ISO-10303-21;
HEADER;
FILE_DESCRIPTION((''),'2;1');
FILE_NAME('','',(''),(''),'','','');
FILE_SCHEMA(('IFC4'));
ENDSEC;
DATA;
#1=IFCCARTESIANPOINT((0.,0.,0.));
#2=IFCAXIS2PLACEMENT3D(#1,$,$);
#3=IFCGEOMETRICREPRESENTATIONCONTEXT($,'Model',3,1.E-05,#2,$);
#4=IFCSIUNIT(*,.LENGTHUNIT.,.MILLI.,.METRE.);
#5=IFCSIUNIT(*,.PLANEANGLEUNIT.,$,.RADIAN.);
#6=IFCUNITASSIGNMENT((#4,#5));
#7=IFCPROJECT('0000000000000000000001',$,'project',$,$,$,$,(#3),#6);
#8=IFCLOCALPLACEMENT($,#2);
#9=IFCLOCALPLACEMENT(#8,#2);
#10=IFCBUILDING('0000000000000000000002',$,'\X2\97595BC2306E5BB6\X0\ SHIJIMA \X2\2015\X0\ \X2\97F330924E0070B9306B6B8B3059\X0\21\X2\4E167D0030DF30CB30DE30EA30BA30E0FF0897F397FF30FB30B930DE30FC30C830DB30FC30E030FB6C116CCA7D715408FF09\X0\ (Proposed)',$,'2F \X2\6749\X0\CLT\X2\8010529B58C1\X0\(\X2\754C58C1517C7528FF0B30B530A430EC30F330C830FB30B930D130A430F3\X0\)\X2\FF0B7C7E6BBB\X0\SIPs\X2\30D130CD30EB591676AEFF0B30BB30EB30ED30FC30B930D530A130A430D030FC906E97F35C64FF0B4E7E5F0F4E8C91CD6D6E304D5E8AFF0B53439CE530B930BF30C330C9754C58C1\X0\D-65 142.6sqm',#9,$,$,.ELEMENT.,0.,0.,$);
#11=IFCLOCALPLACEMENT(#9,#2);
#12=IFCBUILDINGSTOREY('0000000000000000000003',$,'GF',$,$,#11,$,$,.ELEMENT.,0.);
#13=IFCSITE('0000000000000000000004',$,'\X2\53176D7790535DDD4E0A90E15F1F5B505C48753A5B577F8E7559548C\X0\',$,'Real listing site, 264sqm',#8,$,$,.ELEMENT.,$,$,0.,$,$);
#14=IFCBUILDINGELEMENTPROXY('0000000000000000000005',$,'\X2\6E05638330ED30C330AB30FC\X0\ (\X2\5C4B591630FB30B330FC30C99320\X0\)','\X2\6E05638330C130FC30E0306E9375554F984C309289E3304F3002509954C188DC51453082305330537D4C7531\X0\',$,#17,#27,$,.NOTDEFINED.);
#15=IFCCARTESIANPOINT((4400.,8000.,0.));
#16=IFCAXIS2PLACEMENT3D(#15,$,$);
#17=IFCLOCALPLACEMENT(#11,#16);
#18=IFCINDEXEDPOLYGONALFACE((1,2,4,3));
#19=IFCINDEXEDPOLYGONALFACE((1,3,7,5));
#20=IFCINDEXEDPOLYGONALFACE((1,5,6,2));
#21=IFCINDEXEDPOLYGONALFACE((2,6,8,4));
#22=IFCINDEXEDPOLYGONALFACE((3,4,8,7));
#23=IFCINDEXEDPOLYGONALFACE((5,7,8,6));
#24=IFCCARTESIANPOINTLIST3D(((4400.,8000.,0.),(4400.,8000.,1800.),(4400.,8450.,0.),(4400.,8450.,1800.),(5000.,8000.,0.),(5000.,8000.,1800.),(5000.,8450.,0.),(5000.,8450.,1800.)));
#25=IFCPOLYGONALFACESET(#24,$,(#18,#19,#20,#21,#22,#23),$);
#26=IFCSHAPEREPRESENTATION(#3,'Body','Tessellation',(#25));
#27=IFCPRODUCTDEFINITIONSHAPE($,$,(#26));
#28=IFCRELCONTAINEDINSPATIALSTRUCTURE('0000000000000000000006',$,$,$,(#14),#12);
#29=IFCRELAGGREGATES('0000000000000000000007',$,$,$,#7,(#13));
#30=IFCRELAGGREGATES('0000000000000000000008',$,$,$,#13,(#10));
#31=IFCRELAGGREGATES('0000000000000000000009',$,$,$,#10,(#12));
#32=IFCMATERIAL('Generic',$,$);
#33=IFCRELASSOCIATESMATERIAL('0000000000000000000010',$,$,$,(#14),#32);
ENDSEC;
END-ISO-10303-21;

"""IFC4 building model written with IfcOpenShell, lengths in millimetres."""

from ifc_helpers import new_model, si_unit, frame, frame_2d, origin, place, context, project, spatial, rectangle, extrude, material, element, save


model = new_model("IFC4")

# Units and contexts
model_context = context("Model", 3, precision=1e-05, world=origin())
ifc_project = project(units=[si_unit("LENGTHUNIT", "METRE", prefix="MILLI"), si_unit("PLANEANGLEUNIT", "RADIAN")], contexts=[model_context])

# Site, building, storey
site_placement = place(None, origin())
site = spatial("IfcSite", under=ifc_project, at=site_placement, Name="北海道川上郡弟子屈町字美留和", ObjectType="Real listing site, 264sqm", CompositionType="ELEMENT", RefElevation=0.0)
building_placement = place(site_placement, origin())
building = spatial("IfcBuilding", under=site, at=building_placement, Name="静寂の家 SHIJIMA ― 音を一点に残す21世紀ミニマリズム（音響・スマートホーム・民泊統合） (Proposed)", ObjectType="2F 杉CLT耐力壁(界壁兼用＋サイレント・スパイン)＋籾殻SIPsパネル外皮＋セルロースファイバー遮音層＋乾式二重浮き床＋千鳥スタッド界壁D-65 142.6sqm", CompositionType="ELEMENT", ElevationOfRefHeight=0.0, ElevationOfTerrain=0.0)
storey_placement = place(building_placement, origin())
storey = spatial("IfcBuildingStorey", under=building, at=storey_placement, Name="GF", CompositionType="ELEMENT", Elevation=0.0)

# Shared definitions
ifc_material = material(Name="Generic")

# Building element proxy
proxy_placement = place(storey_placement, frame((4400.0, 8000.0, 0.0)))
element("IfcBuildingElementProxy", 1, at=proxy_placement, inside=storey, material=ifc_material, Name="清掃ロッカー (屋外・コード錠)", Description="清掃チームの鍵問題を解く。備品補充もここ経由", PredefinedType="NOTDEFINED", context=model_context, shape_type="SweptSolid", body=[
    extrude(rectangle(XDim=600.0, YDim=450.0, at=frame_2d((300.0, 225.0))), frame((4400.0, 8000.0, 0.0)), (0.0, 0.0, 1.0), 1800.0),
])

save(model, "model.ifc")
